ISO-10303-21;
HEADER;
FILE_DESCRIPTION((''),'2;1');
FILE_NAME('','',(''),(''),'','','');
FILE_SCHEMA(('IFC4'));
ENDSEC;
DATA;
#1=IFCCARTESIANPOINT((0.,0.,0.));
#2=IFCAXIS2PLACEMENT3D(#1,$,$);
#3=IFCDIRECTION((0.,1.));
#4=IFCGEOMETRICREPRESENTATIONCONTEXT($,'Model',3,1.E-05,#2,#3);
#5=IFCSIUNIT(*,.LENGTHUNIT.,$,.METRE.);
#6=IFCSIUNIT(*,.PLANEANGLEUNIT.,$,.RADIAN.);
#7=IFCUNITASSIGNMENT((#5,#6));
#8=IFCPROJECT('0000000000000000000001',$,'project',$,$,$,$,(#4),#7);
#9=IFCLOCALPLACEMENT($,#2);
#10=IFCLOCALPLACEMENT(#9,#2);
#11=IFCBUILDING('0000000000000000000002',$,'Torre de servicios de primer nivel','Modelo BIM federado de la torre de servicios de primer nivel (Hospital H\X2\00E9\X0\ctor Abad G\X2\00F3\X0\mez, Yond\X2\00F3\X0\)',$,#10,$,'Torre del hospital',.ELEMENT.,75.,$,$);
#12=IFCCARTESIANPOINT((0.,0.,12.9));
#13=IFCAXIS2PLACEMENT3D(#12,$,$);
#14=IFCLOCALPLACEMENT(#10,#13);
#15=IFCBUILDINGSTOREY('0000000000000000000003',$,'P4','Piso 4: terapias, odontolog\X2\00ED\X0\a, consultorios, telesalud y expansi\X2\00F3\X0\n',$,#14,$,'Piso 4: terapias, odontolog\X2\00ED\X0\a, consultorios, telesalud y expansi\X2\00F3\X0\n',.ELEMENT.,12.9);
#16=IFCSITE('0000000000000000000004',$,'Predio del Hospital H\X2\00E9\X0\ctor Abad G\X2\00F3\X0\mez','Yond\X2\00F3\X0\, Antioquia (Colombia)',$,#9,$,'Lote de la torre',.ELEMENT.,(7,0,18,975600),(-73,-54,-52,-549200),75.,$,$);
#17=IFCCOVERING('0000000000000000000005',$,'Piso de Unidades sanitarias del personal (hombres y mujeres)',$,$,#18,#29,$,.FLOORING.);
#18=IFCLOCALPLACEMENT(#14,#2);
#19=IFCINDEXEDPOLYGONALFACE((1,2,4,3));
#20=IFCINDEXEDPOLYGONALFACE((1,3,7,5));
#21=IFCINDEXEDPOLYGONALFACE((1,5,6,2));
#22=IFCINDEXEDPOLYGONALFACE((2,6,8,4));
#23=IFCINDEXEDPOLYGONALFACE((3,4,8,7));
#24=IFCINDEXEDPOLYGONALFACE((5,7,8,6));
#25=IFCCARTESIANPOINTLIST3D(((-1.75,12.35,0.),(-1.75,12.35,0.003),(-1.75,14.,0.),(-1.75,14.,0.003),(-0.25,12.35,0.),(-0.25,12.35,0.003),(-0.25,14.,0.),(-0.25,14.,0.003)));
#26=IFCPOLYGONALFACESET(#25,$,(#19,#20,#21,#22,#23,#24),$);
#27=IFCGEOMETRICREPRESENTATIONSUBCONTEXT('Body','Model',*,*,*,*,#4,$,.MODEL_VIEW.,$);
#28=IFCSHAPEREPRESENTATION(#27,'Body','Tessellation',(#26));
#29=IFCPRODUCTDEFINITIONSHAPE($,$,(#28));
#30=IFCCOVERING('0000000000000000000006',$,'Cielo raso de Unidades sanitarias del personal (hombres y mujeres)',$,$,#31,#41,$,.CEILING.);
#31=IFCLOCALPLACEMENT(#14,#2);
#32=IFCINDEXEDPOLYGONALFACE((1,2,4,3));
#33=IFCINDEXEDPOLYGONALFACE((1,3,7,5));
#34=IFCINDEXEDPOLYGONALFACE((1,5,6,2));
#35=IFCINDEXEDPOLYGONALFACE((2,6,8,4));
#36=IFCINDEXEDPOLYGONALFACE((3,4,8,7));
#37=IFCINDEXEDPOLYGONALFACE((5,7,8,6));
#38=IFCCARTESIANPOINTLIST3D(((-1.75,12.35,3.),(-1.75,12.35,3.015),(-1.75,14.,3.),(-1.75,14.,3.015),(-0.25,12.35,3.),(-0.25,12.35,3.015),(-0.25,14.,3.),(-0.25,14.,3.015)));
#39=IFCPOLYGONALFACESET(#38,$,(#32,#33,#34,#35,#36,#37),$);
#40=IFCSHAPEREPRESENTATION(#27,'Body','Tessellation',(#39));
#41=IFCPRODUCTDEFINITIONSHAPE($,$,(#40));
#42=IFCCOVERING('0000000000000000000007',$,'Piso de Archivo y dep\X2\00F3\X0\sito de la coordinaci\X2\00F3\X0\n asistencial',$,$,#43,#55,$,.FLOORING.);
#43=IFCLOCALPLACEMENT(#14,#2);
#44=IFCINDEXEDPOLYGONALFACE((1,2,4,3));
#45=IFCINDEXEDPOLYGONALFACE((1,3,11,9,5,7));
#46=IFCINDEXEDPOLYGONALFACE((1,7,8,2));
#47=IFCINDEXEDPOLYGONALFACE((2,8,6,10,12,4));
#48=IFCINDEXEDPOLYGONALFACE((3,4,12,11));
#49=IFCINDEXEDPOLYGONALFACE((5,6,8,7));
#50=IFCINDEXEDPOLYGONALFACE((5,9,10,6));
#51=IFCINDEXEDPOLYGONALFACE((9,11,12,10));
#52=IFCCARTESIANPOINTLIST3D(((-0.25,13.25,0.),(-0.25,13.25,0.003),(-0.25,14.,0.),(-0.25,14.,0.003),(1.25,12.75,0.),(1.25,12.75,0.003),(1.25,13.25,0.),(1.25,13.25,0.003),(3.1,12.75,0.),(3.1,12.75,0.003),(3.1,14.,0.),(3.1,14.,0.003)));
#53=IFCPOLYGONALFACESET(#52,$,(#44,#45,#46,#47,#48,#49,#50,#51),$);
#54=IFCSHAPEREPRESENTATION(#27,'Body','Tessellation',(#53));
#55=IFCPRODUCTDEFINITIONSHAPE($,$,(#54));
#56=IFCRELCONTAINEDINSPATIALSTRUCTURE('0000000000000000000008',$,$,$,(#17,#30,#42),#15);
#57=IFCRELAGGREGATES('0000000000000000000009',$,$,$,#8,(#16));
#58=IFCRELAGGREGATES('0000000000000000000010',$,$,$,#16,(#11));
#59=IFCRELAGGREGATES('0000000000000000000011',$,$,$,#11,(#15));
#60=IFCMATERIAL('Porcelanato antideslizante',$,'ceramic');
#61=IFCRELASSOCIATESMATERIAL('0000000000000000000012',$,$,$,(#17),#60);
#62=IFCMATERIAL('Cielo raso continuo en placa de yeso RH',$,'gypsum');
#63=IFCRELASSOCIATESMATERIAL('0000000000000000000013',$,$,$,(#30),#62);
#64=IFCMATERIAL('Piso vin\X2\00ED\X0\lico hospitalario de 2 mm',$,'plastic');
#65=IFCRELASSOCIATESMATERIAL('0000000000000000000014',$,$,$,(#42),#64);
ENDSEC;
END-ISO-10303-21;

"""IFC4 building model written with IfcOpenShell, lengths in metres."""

from ifc_helpers import new_model, si_unit, direction, frame, origin, place, context, subcontext, project, spatial, indexed_curve, outline, extrude, material, element, save


model = new_model("IFC4")

# Units and contexts
model_context = context("Model", 3, precision=1e-05, world=origin(), true_north=direction((0.0, 1.0)))
body_context = subcontext(model_context, "Body", "Model", "MODEL_VIEW")
ifc_project = project(units=[si_unit("LENGTHUNIT", "METRE"), si_unit("PLANEANGLEUNIT", "RADIAN")], contexts=[model_context])

# Site, building, storey
site_placement = place(None, origin())
site = spatial("IfcSite", under=ifc_project, at=site_placement, Name="Predio del Hospital Héctor Abad Gómez", Description="Yondó, Antioquia (Colombia)", LongName="Lote de la torre", CompositionType="ELEMENT", RefLatitude=(7, 0, 18, 975600), RefLongitude=(-73, -54, -52, -549200), RefElevation=75.0)
building_placement = place(site_placement, origin())
building = spatial("IfcBuilding", under=site, at=building_placement, Name="Torre de servicios de primer nivel", Description="Modelo BIM federado de la torre de servicios de primer nivel (Hospital Héctor Abad Gómez, Yondó)", LongName="Torre del hospital", CompositionType="ELEMENT", ElevationOfRefHeight=75.0)
placement = place(building_placement, frame((0.0, 0.0, 12.9)))
storey = spatial("IfcBuildingStorey", under=building, at=placement, Name="P4", Description="Piso 4: terapias, odontología, consultorios, telesalud y expansión", LongName="Piso 4: terapias, odontología, consultorios, telesalud y expansión", CompositionType="ELEMENT", Elevation=12.9)

# Coverings
ifc_material_1 = material(Name="Porcelanato antideslizante", Category="ceramic")
ifc_material_2 = material(Name="Cielo raso continuo en placa de yeso RH", Category="gypsum")
ifc_material_3 = material(Name="Piso vinílico hospitalario de 2 mm", Category="plastic")
element("IfcCovering", 1, at=placement, inside=storey, material=ifc_material_1, Name="Piso de Unidades sanitarias del personal (hombres y mujeres)", PredefinedType="FLOORING", context=body_context, shape_type="SweptSolid", body=[
    extrude(outline(indexed_curve([(-1.75, 12.35), (-0.25, 12.35), (-0.25, 14.0), (-1.75, 14.0), (-1.75, 12.35)], self_intersect=False)), origin(), (0.0, 0.0, 1.0), 0.003),
])
element("IfcCovering", 2, at=placement, inside=storey, material=ifc_material_2, Name="Cielo raso de Unidades sanitarias del personal (hombres y mujeres)", PredefinedType="CEILING", context=body_context, shape_type="SweptSolid", body=[
    extrude(outline(indexed_curve([(-1.75, 12.35), (-0.25, 12.35), (-0.25, 14.0), (-1.75, 14.0), (-1.75, 12.35)], self_intersect=False)), frame((0.0, 0.0, 3.0)), (0.0, 0.0, 1.0), 0.015),
])
element("IfcCovering", 3, at=placement, inside=storey, material=ifc_material_3, Name="Piso de Archivo y depósito de la coordinación asistencial", PredefinedType="FLOORING", context=body_context, shape_type="SweptSolid", body=[
    extrude(outline(indexed_curve([(-0.25, 13.25), (1.25, 13.25), (1.25, 12.75), (3.1, 12.75), (3.1, 14.0), (-0.25, 14.0), (-0.25, 13.25)], self_intersect=False)), origin(), (0.0, 0.0, 1.0), 0.003),
])

save(model, "model.ifc")
